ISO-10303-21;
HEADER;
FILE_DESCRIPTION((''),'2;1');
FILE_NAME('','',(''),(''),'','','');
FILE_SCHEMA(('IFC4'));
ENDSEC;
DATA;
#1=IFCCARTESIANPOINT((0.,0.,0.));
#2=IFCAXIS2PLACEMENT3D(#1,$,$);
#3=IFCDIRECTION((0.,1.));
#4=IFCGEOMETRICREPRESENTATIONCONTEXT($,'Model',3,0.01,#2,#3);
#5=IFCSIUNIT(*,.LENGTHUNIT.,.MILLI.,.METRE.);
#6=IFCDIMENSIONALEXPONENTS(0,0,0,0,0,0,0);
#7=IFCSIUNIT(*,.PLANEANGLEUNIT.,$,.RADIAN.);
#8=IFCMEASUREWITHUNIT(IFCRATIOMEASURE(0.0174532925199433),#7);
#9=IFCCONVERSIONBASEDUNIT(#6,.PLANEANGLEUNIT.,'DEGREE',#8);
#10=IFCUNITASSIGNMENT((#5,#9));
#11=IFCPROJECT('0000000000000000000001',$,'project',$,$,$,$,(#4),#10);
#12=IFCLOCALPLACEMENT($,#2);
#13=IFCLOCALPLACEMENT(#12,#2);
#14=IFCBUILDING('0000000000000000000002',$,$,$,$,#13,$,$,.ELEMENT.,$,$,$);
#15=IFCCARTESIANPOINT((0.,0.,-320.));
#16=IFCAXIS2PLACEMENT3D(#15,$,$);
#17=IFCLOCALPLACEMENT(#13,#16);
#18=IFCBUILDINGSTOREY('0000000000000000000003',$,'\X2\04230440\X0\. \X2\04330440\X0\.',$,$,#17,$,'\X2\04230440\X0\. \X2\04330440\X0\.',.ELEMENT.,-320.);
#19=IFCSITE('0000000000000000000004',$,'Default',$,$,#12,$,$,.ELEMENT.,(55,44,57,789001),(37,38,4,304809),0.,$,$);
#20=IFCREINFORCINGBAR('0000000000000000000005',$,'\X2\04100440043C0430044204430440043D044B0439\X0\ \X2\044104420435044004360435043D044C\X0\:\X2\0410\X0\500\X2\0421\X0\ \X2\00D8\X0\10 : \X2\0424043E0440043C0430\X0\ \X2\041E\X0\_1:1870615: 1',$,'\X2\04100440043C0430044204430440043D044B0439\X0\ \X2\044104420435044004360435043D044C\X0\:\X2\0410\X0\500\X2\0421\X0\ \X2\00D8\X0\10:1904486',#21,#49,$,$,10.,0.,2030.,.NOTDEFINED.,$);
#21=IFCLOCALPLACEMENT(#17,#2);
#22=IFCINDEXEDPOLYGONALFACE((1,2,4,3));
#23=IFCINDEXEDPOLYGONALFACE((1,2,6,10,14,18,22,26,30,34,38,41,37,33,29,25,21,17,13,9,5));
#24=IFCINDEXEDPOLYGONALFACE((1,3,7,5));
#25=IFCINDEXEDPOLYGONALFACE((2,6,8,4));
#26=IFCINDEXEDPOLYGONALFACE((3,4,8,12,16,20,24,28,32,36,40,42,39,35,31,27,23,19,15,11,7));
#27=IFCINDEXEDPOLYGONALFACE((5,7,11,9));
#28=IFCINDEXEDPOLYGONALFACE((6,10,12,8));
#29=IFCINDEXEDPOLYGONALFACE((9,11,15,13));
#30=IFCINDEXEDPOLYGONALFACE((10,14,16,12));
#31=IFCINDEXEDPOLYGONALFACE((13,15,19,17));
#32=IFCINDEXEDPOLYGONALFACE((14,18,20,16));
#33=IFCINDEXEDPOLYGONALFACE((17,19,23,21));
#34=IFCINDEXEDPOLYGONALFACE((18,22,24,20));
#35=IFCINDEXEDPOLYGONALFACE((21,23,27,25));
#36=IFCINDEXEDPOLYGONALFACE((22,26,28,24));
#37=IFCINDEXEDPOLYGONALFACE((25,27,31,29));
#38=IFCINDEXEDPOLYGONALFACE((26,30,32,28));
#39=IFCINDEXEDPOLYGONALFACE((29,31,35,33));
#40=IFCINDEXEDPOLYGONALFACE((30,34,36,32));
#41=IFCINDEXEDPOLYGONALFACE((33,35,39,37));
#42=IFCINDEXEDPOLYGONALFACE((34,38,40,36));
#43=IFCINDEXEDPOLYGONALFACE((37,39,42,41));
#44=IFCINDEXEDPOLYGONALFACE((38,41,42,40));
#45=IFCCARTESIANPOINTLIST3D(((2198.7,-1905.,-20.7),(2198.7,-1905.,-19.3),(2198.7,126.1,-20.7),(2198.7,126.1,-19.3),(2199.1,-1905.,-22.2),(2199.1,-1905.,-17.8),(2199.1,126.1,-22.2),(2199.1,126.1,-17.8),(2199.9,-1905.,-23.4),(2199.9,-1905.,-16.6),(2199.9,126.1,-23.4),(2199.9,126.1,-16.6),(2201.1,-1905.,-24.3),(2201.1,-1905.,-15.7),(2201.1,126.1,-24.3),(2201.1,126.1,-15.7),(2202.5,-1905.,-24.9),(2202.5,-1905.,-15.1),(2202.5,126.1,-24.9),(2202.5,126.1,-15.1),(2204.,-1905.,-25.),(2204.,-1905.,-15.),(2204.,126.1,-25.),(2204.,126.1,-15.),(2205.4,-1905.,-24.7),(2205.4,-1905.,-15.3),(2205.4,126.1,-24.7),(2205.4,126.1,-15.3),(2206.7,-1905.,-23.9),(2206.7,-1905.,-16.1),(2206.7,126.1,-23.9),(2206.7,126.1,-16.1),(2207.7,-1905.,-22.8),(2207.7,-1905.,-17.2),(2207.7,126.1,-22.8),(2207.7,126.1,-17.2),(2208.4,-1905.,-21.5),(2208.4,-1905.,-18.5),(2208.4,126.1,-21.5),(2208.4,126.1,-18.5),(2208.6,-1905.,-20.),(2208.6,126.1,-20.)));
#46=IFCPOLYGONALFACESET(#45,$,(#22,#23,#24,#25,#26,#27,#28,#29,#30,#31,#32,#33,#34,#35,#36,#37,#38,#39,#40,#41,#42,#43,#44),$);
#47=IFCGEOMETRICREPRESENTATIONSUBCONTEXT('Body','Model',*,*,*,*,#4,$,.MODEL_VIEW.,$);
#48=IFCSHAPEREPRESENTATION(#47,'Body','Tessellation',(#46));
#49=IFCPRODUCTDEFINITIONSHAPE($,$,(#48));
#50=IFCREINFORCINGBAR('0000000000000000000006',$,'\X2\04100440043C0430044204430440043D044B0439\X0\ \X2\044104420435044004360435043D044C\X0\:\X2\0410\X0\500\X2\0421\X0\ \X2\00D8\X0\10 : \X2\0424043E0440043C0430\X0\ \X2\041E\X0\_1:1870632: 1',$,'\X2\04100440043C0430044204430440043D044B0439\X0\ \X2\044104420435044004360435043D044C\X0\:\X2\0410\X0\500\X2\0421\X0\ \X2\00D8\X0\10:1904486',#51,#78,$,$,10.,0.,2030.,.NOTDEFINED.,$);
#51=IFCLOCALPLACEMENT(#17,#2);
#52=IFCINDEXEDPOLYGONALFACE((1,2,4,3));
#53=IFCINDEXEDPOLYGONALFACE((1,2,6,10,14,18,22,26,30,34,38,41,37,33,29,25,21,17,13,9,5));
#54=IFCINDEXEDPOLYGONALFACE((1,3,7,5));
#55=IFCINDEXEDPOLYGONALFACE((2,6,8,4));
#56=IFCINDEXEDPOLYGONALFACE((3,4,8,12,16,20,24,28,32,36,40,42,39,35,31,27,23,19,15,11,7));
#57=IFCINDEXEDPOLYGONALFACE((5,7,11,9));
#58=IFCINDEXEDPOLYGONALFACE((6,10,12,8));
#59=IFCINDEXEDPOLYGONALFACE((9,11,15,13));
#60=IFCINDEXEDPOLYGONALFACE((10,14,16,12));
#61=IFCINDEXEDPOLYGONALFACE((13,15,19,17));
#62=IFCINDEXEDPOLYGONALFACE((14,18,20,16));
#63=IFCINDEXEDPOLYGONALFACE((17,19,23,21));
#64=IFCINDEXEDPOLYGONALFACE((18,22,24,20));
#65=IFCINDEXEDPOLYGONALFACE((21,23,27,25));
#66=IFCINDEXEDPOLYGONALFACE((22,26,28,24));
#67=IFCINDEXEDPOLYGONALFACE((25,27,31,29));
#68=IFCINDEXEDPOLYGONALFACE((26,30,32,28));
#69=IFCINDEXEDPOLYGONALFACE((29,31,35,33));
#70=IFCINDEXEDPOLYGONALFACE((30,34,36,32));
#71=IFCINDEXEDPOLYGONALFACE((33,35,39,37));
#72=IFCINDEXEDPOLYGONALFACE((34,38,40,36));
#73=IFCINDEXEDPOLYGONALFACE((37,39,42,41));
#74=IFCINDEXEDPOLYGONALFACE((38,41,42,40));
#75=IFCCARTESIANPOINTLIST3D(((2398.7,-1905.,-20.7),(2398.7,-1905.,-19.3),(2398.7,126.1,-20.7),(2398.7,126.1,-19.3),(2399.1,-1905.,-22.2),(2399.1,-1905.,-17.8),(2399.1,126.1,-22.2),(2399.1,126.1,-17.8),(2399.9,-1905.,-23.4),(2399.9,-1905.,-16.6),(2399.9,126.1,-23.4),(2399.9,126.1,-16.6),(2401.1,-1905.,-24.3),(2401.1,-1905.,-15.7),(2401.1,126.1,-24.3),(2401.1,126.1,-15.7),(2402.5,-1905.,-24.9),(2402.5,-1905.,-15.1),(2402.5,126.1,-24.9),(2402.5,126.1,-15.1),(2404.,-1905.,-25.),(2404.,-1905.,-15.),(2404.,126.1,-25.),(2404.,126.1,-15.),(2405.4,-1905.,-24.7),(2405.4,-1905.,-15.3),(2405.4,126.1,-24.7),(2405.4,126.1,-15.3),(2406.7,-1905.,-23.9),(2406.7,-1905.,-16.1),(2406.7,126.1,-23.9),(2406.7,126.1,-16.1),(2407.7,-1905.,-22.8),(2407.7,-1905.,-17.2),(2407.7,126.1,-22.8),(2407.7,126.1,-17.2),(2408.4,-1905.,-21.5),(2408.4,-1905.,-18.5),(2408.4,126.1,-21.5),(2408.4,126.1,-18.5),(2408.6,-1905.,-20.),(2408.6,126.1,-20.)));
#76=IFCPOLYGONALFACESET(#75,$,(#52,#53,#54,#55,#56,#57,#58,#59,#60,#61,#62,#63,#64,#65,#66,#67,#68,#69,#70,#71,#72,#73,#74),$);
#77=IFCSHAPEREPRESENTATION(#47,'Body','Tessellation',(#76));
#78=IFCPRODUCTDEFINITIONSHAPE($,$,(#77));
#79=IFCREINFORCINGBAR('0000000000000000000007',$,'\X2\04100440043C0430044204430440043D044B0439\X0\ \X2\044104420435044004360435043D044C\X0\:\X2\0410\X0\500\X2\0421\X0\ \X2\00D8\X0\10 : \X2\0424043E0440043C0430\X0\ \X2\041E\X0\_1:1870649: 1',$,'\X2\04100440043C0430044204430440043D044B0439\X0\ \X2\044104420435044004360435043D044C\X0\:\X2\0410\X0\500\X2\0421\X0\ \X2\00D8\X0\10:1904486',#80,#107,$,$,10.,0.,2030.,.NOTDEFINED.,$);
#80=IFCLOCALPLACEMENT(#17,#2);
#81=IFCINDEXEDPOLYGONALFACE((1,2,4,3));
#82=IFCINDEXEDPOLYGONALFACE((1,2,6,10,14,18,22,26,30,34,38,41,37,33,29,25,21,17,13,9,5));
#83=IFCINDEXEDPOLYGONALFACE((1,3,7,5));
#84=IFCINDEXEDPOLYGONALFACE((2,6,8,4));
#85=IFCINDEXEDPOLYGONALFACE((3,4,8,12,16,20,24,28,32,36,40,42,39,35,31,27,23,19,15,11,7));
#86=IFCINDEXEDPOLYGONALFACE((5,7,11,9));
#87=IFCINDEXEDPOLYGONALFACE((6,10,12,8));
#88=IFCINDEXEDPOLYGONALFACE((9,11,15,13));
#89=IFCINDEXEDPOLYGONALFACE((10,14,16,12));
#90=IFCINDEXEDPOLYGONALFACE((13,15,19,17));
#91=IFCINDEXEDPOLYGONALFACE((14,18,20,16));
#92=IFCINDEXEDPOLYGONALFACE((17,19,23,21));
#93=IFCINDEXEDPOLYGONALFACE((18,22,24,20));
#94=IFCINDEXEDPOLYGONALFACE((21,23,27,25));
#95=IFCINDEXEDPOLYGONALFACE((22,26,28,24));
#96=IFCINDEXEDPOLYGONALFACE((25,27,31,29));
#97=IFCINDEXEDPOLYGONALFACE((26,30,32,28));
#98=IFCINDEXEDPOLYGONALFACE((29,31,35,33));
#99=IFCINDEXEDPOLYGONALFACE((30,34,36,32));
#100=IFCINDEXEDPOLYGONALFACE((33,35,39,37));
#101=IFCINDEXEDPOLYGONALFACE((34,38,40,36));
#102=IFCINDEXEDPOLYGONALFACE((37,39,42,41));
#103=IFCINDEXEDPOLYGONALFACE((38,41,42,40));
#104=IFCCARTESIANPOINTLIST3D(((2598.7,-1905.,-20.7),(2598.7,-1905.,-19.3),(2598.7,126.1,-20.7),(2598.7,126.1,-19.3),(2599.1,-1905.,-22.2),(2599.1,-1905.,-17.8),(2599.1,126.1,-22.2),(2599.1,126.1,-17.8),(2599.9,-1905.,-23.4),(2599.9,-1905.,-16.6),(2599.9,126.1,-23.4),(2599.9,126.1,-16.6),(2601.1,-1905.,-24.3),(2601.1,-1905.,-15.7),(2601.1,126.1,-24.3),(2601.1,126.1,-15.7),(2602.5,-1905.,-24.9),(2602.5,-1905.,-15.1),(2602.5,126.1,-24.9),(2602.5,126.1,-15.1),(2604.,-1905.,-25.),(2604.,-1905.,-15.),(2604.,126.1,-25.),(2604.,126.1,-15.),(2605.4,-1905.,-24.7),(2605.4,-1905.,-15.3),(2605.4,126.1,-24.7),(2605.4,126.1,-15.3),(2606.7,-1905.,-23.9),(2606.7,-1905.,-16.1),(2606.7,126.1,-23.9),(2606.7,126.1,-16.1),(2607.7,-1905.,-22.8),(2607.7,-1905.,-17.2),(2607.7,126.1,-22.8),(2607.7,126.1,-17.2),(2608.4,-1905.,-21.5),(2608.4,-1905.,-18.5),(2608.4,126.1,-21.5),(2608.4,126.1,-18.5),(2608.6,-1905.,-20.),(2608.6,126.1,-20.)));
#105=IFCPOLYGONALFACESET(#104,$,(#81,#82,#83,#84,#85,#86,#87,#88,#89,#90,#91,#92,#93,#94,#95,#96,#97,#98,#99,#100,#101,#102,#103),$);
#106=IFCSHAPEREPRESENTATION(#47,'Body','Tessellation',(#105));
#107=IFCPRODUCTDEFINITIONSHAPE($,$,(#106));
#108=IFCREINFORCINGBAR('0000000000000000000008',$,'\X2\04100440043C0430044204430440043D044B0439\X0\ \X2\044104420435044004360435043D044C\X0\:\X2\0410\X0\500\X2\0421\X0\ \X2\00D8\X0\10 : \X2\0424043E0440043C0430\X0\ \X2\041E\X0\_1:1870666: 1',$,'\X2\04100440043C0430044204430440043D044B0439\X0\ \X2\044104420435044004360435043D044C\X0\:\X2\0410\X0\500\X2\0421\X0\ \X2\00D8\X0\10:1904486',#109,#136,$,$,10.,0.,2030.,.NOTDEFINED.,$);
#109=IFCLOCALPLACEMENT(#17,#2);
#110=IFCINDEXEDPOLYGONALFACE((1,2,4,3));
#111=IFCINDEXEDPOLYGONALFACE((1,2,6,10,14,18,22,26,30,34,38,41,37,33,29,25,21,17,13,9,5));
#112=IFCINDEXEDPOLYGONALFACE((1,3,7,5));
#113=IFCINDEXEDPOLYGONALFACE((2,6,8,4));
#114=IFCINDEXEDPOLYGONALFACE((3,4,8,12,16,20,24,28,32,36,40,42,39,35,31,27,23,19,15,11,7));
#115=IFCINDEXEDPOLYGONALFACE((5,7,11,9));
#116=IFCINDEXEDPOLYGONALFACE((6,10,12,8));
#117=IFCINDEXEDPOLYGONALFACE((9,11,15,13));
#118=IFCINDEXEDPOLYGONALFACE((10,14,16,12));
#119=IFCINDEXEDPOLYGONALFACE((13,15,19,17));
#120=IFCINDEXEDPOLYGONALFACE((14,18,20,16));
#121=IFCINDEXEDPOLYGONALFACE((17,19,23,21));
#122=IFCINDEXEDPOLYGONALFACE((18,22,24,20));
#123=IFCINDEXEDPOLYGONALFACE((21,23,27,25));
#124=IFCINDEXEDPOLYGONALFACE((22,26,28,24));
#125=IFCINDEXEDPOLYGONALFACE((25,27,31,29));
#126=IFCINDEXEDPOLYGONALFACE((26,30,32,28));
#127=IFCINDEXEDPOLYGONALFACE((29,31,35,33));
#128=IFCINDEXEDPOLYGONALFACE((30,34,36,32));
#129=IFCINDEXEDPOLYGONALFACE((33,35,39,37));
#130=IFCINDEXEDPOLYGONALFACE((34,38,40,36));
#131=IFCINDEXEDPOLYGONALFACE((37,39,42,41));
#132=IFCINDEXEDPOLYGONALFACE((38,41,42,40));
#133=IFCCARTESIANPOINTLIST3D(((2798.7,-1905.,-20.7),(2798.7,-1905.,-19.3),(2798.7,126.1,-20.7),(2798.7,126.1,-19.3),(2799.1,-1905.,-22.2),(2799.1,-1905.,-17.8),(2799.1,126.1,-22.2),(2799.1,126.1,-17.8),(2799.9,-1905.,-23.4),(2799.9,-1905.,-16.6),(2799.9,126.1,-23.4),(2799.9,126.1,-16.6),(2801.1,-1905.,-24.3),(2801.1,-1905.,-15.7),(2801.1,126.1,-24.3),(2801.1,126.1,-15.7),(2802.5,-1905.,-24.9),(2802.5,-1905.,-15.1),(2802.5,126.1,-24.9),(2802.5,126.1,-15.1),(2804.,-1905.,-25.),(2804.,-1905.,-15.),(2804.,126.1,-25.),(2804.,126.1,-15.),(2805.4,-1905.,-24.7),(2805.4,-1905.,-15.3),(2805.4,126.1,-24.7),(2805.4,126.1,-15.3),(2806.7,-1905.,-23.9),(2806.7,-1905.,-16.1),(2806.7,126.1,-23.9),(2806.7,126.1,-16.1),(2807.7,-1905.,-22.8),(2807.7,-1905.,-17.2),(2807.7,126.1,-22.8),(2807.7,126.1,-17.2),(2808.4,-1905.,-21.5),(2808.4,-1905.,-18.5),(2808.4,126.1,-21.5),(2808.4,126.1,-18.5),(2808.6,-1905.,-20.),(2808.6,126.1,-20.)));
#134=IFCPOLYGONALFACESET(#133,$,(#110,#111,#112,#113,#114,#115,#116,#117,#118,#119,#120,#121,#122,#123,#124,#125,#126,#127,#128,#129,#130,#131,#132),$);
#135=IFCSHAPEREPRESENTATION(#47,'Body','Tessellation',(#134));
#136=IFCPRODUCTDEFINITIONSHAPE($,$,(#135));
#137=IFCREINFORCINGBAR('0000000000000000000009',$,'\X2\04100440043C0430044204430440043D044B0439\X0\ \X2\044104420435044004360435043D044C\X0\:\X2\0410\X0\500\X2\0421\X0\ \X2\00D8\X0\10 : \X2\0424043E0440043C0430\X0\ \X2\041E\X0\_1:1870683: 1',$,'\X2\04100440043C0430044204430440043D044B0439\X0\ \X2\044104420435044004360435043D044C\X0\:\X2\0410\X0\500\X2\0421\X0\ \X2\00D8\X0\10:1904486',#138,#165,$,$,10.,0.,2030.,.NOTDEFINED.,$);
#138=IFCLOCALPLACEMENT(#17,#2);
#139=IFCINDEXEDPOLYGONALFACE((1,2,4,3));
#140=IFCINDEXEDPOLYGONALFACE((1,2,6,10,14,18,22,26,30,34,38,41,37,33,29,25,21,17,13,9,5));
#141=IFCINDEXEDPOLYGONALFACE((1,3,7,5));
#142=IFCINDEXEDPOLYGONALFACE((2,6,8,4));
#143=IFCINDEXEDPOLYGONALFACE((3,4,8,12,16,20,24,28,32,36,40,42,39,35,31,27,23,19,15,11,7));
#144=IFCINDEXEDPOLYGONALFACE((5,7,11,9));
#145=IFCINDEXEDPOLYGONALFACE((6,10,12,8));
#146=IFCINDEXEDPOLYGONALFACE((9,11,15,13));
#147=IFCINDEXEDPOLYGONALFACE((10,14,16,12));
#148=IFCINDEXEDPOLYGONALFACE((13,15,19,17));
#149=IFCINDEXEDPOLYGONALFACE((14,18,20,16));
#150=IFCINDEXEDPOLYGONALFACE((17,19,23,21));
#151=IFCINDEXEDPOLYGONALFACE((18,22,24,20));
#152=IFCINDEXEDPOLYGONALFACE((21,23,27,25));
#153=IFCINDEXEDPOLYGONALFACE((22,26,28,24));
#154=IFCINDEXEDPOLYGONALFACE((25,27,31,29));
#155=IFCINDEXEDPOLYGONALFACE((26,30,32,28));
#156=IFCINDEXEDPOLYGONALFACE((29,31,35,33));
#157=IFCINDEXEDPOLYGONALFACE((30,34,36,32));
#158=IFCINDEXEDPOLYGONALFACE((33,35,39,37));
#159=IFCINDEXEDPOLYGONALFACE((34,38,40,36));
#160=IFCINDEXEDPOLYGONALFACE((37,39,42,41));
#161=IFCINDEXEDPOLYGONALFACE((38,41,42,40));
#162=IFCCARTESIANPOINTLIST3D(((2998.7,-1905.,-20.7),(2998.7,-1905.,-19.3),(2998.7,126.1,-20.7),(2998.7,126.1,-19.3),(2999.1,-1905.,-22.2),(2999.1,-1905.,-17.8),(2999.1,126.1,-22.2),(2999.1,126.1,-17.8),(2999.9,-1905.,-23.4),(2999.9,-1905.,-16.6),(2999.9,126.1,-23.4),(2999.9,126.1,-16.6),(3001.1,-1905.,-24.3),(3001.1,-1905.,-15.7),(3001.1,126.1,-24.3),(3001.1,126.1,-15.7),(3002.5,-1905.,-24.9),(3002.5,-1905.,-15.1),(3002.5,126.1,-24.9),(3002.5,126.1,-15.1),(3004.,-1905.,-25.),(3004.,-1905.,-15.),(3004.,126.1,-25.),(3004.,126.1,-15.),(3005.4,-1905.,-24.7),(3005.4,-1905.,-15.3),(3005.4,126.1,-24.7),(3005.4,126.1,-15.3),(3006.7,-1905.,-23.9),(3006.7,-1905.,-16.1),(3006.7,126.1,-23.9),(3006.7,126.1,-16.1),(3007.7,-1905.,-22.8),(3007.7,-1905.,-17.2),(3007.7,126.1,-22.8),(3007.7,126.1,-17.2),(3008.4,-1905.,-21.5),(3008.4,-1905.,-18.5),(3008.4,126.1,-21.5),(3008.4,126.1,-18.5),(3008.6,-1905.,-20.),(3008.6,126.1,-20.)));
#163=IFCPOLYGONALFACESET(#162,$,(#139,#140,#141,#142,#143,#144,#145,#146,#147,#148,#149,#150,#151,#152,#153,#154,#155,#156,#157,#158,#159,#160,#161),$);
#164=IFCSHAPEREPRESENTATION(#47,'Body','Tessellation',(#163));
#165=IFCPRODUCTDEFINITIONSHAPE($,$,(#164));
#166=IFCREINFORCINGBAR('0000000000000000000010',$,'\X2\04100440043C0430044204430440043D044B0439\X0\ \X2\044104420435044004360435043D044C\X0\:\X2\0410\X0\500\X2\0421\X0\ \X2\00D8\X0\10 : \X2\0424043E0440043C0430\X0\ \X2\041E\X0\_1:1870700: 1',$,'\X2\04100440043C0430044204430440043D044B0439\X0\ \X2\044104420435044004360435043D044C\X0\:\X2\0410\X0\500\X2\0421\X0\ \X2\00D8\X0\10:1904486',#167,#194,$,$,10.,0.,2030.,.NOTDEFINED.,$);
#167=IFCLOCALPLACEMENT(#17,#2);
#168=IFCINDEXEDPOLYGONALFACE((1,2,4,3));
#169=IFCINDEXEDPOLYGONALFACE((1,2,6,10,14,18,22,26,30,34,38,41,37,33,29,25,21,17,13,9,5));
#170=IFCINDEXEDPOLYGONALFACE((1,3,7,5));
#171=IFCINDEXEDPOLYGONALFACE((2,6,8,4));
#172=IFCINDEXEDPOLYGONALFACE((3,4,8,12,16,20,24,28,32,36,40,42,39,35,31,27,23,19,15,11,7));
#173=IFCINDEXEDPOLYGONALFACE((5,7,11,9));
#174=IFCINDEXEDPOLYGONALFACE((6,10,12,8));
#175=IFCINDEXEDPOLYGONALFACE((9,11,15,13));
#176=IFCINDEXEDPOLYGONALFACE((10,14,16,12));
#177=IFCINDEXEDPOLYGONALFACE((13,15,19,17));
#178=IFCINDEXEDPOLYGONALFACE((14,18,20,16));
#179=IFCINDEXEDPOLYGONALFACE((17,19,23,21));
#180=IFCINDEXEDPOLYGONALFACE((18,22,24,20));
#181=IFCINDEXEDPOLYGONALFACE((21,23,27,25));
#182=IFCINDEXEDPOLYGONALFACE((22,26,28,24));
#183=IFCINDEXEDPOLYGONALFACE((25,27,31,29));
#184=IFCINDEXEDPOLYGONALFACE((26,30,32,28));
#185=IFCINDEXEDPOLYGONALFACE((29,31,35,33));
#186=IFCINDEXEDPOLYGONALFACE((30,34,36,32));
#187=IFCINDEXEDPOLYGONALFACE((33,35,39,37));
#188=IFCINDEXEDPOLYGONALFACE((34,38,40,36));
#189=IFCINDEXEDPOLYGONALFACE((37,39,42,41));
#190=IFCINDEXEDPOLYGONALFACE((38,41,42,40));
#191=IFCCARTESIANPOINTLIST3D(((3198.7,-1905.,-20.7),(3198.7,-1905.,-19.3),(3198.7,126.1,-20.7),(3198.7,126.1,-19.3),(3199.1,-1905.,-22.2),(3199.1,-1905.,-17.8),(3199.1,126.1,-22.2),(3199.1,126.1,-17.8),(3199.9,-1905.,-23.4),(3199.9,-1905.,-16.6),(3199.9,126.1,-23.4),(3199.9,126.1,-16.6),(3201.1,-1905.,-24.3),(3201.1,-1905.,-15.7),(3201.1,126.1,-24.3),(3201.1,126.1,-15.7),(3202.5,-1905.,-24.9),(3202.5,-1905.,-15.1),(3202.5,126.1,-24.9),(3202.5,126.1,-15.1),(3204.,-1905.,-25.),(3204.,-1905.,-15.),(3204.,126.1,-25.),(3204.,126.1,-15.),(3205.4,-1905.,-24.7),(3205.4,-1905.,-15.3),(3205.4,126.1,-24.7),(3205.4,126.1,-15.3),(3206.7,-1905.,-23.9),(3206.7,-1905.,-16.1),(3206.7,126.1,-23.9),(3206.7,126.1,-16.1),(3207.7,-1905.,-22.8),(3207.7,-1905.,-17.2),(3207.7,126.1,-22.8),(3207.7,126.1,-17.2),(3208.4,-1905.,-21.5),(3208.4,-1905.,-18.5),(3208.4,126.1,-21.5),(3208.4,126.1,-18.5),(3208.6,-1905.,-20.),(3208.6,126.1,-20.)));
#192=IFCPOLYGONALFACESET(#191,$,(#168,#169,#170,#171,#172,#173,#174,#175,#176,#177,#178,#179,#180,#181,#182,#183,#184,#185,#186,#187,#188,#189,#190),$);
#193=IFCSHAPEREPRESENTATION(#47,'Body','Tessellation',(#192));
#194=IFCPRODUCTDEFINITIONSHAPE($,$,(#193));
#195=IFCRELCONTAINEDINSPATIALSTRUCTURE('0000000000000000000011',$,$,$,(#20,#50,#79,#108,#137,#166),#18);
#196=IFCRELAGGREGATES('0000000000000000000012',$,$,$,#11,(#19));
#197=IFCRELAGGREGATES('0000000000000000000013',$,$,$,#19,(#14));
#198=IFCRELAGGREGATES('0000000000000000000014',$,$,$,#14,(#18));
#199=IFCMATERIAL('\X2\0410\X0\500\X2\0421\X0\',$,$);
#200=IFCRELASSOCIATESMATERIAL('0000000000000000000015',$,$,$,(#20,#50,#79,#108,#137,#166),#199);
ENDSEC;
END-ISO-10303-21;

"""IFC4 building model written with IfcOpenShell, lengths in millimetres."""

from ifc_helpers import new_model, entity, si_unit, converted_unit, direction, frame, origin, place, context, subcontext, project, spatial, material, element, save


model = new_model("IFC4")

# Units and contexts
model_context = context("Model", 3, precision=0.01, world=origin(), true_north=direction((0.0, 1.0)))
body_context = subcontext(model_context, "Body", "Model", "MODEL_VIEW")
ifc_project = project(units=[si_unit("LENGTHUNIT", "METRE", prefix="MILLI"), converted_unit("PLANEANGLEUNIT", "DEGREE", entity("IfcRatioMeasure", 0.0174532925199433), si_unit("PLANEANGLEUNIT", "RADIAN"), dimensions=[0, 0, 0, 0, 0, 0, 0])], contexts=[model_context])

# Site, building, storey
site_placement = place(None, origin())
site = spatial("IfcSite", under=ifc_project, at=site_placement, Name="Default", CompositionType="ELEMENT", RefLatitude=(55, 44, 57, 789001), RefLongitude=(37, 38, 4, 304809), RefElevation=0.0)
building_placement = place(site_placement, origin())
building = spatial("IfcBuilding", under=site, at=building_placement, CompositionType="ELEMENT")
storey_placement = place(building_placement, frame((0.0, 0.0, -320.0)))
storey = spatial("IfcBuildingStorey", under=building, at=storey_placement, Name="Ур. гр.", LongName="Ур. гр.", CompositionType="ELEMENT", Elevation=-320.0)

# Reinforcing bars
ifc_material_1 = material(Name="А500С")
reinforcing_bar_1_placement = place(storey_placement, origin())
element("IfcReinforcingBar", 1, at=reinforcing_bar_1_placement, inside=storey, material=ifc_material_1, Name="Арматурный стержень:А500С Ø10 : Форма О_1:1870615: 1", ObjectType="Арматурный стержень:А500С Ø10:1904486", BarLength=2030.0, CrossSectionArea=0.0, NominalDiameter=10.0, PredefinedType="NOTDEFINED", context=body_context, shape_type="AdvancedSweptSolid", body=[
    entity("IfcSweptDiskSolid", entity("IfcCompositeCurve", [entity("IfcCompositeCurveSegment", "CONTINUOUS", True, entity("IfcPolyline", [entity("IfcCartesianPoint", [2203.6, -1905.0, -20.0]), entity("IfcCartesianPoint", [2203.6, 126.1, -20.0])]))], False), 5.0, None, 0.0, 1.0),
])
reinforcing_bar_2_placement = place(storey_placement, origin())
element("IfcReinforcingBar", 2, at=reinforcing_bar_2_placement, inside=storey, material=ifc_material_1, Name="Арматурный стержень:А500С Ø10 : Форма О_1:1870632: 1", ObjectType="Арматурный стержень:А500С Ø10:1904486", BarLength=2030.0, CrossSectionArea=0.0, NominalDiameter=10.0, PredefinedType="NOTDEFINED", context=body_context, shape_type="AdvancedSweptSolid", body=[
    entity("IfcSweptDiskSolid", entity("IfcCompositeCurve", [entity("IfcCompositeCurveSegment", "CONTINUOUS", True, entity("IfcPolyline", [entity("IfcCartesianPoint", [2403.6, -1905.0, -20.0]), entity("IfcCartesianPoint", [2403.6, 126.1, -20.0])]))], False), 5.0, None, 0.0, 1.0),
])
reinforcing_bar_3_placement = place(storey_placement, origin())
element("IfcReinforcingBar", 3, at=reinforcing_bar_3_placement, inside=storey, material=ifc_material_1, Name="Арматурный стержень:А500С Ø10 : Форма О_1:1870649: 1", ObjectType="Арматурный стержень:А500С Ø10:1904486", BarLength=2030.0, CrossSectionArea=0.0, NominalDiameter=10.0, PredefinedType="NOTDEFINED", context=body_context, shape_type="AdvancedSweptSolid", body=[
    entity("IfcSweptDiskSolid", entity("IfcCompositeCurve", [entity("IfcCompositeCurveSegment", "CONTINUOUS", True, entity("IfcPolyline", [entity("IfcCartesianPoint", [2603.6, -1905.0, -20.0]), entity("IfcCartesianPoint", [2603.6, 126.1, -20.0])]))], False), 5.0, None, 0.0, 1.0),
])
reinforcing_bar_4_placement = place(storey_placement, origin())
element("IfcReinforcingBar", 4, at=reinforcing_bar_4_placement, inside=storey, material=ifc_material_1, Name="Арматурный стержень:А500С Ø10 : Форма О_1:1870666: 1", ObjectType="Арматурный стержень:А500С Ø10:1904486", BarLength=2030.0, CrossSectionArea=0.0, NominalDiameter=10.0, PredefinedType="NOTDEFINED", context=body_context, shape_type="AdvancedSweptSolid", body=[
    entity("IfcSweptDiskSolid", entity("IfcCompositeCurve", [entity("IfcCompositeCurveSegment", "CONTINUOUS", True, entity("IfcPolyline", [entity("IfcCartesianPoint", [2803.6, -1905.0, -20.0]), entity("IfcCartesianPoint", [2803.6, 126.1, -20.0])]))], False), 5.0, None, 0.0, 1.0),
])
reinforcing_bar_5_placement = place(storey_placement, origin())
element("IfcReinforcingBar", 5, at=reinforcing_bar_5_placement, inside=storey, material=ifc_material_1, Name="Арматурный стержень:А500С Ø10 : Форма О_1:1870683: 1", ObjectType="Арматурный стержень:А500С Ø10:1904486", BarLength=2030.0, CrossSectionArea=0.0, NominalDiameter=10.0, PredefinedType="NOTDEFINED", context=body_context, shape_type="AdvancedSweptSolid", body=[
    entity("IfcSweptDiskSolid", entity("IfcCompositeCurve", [entity("IfcCompositeCurveSegment", "CONTINUOUS", True, entity("IfcPolyline", [entity("IfcCartesianPoint", [3003.6, -1905.0, -20.0]), entity("IfcCartesianPoint", [3003.6, 126.1, -20.0])]))], False), 5.0, None, 0.0, 1.0),
])
reinforcing_bar_6_placement = place(storey_placement, origin())
element("IfcReinforcingBar", 6, at=reinforcing_bar_6_placement, inside=storey, material=ifc_material_1, Name="Арматурный стержень:А500С Ø10 : Форма О_1:1870700: 1", ObjectType="Арматурный стержень:А500С Ø10:1904486", BarLength=2030.0, CrossSectionArea=0.0, NominalDiameter=10.0, PredefinedType="NOTDEFINED", context=body_context, shape_type="AdvancedSweptSolid", body=[
    entity("IfcSweptDiskSolid", entity("IfcCompositeCurve", [entity("IfcCompositeCurveSegment", "CONTINUOUS", True, entity("IfcPolyline", [entity("IfcCartesianPoint", [3203.6, -1905.0, -20.0]), entity("IfcCartesianPoint", [3203.6, 126.1, -20.0])]))], False), 5.0, None, 0.0, 1.0),
])

save(model, "model.ifc")
